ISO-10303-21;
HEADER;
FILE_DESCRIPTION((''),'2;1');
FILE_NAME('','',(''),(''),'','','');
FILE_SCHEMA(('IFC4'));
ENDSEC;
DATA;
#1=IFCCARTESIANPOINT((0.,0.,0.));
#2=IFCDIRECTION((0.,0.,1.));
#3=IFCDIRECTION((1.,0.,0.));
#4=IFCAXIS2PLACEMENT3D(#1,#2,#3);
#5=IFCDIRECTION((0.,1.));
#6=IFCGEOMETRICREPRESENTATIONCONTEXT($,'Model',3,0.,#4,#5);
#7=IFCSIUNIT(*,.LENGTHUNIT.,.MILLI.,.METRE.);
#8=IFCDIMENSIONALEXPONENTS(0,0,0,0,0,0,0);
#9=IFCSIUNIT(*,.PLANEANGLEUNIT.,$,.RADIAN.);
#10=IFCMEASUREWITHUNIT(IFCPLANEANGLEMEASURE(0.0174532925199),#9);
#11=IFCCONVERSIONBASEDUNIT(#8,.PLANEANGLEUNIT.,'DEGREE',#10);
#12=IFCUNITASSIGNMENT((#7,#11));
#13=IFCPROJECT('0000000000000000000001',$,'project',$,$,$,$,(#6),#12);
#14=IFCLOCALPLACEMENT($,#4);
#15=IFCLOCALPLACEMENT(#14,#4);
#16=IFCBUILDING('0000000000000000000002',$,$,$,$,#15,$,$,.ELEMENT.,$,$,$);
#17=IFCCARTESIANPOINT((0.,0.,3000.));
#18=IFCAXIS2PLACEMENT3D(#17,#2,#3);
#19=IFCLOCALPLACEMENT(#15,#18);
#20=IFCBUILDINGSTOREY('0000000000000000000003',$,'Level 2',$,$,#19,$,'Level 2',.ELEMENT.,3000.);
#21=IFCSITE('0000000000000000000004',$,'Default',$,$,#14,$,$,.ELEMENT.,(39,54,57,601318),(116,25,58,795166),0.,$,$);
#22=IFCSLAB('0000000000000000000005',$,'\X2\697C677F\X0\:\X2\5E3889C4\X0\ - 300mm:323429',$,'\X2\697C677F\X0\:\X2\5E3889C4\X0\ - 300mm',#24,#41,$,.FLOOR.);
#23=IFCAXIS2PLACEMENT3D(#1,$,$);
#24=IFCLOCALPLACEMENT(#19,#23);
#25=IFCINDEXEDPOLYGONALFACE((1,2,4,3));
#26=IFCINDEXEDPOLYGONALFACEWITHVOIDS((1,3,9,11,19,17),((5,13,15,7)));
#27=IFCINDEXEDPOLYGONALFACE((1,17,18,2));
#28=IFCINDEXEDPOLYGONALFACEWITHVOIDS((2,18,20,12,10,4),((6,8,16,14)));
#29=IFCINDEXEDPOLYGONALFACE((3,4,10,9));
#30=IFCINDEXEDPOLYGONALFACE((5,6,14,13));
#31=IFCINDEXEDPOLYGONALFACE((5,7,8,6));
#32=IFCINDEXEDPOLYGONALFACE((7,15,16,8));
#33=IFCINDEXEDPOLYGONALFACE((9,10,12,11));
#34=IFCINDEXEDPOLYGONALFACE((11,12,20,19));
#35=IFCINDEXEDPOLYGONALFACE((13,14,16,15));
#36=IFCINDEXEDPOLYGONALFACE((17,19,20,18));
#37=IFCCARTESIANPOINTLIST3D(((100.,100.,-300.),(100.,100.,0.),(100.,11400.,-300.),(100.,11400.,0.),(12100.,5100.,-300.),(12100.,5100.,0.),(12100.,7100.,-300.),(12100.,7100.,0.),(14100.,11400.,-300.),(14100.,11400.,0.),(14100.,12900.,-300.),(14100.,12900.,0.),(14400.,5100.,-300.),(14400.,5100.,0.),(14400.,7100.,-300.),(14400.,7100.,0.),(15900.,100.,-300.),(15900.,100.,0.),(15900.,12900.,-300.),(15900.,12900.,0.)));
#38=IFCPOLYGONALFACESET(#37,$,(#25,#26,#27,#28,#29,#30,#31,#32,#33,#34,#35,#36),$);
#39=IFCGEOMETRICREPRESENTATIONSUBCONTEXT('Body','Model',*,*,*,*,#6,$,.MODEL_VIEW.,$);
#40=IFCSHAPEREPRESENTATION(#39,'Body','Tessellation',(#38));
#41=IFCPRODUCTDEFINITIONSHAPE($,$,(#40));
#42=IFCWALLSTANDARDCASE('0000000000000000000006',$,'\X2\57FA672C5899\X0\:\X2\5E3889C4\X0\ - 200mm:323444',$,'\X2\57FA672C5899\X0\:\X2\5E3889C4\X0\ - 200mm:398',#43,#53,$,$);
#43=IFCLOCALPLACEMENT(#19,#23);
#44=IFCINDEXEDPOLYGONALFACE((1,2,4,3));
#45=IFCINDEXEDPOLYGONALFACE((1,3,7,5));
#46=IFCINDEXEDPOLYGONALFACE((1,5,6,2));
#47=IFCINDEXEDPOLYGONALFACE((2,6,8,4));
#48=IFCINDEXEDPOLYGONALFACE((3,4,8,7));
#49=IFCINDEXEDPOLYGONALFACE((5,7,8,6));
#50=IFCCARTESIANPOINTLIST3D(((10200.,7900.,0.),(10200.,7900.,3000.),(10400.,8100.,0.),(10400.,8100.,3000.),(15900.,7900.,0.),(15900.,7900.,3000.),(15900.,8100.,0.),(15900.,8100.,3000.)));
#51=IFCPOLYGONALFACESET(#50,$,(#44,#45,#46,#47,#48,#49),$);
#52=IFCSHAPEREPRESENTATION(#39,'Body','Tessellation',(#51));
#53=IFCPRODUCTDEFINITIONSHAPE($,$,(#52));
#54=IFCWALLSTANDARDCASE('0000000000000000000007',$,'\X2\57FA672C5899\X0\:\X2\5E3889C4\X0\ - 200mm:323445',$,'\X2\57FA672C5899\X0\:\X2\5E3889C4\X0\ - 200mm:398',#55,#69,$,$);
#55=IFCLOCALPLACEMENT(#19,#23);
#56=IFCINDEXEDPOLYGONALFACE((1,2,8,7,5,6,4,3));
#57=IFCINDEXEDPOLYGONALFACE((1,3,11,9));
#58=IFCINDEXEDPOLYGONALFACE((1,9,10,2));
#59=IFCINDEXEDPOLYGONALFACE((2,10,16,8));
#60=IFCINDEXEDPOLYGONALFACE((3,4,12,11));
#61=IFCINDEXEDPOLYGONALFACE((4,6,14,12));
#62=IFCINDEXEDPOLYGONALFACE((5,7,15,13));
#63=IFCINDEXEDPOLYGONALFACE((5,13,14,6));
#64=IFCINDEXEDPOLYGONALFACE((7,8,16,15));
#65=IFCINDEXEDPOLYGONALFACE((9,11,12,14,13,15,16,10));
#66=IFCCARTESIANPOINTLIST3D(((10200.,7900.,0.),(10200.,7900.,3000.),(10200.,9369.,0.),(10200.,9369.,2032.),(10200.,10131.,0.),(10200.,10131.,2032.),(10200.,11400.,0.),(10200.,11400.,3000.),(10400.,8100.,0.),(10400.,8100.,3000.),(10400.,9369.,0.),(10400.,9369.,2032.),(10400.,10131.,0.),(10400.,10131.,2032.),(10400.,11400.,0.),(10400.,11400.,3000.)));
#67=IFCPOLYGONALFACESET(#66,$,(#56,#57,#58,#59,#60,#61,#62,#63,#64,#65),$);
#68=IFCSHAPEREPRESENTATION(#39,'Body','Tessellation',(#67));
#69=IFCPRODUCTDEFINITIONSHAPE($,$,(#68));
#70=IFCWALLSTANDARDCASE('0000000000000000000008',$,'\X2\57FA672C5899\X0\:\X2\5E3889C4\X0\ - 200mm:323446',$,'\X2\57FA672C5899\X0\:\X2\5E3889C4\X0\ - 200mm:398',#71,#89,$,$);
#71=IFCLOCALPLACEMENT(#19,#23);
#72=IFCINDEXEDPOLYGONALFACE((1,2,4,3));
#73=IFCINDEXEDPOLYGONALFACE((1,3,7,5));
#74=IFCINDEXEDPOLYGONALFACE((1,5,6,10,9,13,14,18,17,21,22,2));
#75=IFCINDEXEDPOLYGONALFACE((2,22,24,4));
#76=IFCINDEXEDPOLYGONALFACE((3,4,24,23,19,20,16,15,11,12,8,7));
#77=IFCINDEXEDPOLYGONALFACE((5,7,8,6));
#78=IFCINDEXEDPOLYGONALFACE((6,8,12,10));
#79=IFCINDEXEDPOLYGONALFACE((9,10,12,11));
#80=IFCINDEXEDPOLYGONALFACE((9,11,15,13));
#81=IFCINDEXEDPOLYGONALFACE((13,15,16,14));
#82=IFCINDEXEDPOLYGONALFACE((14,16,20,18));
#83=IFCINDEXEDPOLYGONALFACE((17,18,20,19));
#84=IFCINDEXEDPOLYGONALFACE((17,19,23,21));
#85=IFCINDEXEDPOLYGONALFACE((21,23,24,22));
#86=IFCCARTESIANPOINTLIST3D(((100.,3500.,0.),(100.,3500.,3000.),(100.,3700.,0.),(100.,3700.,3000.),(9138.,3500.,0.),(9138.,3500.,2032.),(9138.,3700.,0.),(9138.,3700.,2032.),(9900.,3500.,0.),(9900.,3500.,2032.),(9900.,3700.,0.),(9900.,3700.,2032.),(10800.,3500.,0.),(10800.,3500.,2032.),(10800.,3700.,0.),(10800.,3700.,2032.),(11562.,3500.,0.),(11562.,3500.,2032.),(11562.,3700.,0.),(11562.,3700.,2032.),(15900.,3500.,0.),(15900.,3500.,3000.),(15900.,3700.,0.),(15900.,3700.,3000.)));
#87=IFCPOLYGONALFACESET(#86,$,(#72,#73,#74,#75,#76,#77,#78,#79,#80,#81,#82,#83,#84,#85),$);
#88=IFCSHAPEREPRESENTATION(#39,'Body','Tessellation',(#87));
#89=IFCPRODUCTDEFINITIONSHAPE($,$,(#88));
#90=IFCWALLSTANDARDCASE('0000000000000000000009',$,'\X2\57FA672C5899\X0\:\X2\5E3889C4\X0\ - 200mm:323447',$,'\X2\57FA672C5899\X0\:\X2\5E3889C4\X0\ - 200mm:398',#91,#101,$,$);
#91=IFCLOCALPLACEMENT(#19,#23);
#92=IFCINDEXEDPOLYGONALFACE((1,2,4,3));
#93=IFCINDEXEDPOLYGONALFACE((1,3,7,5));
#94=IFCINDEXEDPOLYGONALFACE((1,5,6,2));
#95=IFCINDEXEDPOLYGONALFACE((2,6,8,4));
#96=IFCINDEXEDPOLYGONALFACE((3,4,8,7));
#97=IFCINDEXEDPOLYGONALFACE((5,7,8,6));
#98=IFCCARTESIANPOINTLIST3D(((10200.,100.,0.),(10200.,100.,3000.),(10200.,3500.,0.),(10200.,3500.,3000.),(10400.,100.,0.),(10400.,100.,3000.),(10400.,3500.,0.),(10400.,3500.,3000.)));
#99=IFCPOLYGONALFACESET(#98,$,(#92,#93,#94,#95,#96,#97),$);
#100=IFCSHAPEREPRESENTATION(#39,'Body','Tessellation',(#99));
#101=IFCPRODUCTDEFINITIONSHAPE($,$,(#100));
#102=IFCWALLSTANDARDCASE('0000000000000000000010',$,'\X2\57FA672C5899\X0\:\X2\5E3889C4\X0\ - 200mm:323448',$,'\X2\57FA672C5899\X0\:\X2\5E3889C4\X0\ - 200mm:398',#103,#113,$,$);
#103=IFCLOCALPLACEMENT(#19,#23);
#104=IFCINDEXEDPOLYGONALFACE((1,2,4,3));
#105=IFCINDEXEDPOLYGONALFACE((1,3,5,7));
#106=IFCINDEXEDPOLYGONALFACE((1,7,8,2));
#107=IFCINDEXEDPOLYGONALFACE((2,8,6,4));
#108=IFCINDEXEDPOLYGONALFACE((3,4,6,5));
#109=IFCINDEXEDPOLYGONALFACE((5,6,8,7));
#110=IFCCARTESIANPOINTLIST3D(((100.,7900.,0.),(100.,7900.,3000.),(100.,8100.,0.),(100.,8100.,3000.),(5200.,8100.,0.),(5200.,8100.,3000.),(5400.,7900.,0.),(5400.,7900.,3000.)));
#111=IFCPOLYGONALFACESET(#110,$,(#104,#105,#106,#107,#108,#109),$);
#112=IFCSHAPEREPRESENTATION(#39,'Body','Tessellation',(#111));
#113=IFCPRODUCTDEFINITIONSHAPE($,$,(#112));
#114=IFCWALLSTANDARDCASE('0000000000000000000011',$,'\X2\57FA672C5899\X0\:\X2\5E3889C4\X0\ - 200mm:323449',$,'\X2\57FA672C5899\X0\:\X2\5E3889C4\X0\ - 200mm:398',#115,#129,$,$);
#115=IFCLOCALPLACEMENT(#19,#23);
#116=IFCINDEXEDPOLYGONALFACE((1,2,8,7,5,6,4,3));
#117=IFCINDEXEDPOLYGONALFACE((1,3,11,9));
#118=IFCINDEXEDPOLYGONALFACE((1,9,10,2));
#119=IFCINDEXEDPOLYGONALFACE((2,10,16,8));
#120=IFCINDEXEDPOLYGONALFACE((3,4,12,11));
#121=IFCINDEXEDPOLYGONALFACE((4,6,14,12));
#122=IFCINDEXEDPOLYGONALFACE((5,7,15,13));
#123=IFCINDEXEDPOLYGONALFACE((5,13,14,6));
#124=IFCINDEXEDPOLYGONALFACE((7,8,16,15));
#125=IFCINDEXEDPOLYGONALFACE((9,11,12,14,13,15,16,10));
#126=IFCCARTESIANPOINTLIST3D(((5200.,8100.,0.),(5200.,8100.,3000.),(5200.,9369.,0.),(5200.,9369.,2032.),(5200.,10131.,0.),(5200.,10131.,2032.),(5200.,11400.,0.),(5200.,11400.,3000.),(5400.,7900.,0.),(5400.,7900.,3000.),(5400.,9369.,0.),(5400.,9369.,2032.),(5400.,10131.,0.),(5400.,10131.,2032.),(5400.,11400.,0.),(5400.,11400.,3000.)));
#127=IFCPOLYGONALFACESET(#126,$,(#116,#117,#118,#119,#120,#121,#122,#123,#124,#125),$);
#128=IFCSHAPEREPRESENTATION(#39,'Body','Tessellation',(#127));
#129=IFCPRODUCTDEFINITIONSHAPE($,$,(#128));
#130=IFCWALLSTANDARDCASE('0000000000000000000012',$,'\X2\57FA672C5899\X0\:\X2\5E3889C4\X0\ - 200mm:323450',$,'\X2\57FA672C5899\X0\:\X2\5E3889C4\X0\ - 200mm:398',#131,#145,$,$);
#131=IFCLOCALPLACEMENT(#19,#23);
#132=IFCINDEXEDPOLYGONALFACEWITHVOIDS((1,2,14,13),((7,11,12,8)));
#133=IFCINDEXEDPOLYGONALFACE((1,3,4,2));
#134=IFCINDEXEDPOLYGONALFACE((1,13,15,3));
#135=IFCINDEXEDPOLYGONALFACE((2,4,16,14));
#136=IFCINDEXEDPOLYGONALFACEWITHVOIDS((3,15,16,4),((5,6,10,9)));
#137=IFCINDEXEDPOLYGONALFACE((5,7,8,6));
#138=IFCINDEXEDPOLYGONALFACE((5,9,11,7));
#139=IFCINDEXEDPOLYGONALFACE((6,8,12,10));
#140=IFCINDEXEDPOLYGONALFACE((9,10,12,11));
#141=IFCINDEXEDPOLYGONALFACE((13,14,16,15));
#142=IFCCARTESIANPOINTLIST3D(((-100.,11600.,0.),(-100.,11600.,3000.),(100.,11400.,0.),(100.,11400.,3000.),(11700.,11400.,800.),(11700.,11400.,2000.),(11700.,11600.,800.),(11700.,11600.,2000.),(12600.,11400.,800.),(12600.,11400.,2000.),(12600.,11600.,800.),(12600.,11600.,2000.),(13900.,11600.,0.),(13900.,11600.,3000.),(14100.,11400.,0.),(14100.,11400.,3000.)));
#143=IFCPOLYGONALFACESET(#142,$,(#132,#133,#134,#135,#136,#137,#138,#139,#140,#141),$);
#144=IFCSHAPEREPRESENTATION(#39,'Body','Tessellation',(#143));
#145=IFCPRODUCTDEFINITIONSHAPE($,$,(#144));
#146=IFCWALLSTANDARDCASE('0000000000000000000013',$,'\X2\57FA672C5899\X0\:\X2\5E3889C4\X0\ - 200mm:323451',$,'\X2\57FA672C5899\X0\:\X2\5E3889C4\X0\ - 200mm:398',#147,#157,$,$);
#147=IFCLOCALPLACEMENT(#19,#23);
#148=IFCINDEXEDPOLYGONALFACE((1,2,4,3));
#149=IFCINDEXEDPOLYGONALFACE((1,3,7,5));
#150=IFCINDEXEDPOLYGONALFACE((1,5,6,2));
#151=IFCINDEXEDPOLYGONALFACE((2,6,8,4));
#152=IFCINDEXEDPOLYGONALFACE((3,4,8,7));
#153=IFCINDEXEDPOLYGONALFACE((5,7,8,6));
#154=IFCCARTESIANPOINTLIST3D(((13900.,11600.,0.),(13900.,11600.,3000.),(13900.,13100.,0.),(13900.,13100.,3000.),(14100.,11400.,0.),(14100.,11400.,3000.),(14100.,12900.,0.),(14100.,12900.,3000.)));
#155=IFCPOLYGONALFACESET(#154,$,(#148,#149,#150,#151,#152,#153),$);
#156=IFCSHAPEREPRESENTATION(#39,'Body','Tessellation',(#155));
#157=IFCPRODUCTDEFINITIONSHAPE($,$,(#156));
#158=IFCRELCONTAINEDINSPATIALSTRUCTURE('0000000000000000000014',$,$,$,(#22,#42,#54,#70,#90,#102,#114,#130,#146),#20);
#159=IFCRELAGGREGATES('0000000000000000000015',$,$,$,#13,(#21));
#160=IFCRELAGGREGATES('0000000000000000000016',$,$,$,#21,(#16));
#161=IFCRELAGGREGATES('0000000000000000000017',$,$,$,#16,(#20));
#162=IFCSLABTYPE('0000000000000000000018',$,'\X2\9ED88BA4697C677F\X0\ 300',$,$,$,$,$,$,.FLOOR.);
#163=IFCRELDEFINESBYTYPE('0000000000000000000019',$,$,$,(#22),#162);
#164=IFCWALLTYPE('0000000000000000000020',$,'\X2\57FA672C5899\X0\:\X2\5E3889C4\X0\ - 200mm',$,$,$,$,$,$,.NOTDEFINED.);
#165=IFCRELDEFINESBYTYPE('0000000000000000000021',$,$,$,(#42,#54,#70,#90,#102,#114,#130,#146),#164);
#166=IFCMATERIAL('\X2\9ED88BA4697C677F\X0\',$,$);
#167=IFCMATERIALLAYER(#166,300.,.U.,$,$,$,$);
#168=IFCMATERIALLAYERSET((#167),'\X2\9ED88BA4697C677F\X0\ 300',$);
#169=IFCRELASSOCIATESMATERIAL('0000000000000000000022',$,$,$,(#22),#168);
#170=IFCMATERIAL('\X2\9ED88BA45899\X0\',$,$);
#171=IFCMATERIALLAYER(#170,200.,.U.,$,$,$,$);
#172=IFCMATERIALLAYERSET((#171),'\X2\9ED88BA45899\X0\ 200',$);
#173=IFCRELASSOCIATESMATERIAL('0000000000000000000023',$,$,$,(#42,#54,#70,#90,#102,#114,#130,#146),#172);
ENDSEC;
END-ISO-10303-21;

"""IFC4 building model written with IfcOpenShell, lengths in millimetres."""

from ifc_helpers import new_model, entity, si_unit, converted_unit, direction, frame, origin_with_axes, place, context, subcontext, project, spatial, polyline, outline, extrude, material, layer, layer_set, layer_usage, type_object, element, save


model = new_model("IFC4")

# Units and contexts
model_context = context("Model", 3, precision=0.0, world=origin_with_axes(), true_north=direction((0.0, 1.0)))
body_context = subcontext(model_context, "Body", "Model", "MODEL_VIEW")
ifc_project = project(units=[si_unit("LENGTHUNIT", "METRE", prefix="MILLI"), converted_unit("PLANEANGLEUNIT", "DEGREE", entity("IfcPlaneAngleMeasure", 0.0174532925199), si_unit("PLANEANGLEUNIT", "RADIAN"), dimensions=[0, 0, 0, 0, 0, 0, 0])], contexts=[model_context])

# Site, building, storey
site_placement = place(None, origin_with_axes())
site = spatial("IfcSite", under=ifc_project, at=site_placement, Name="Default", CompositionType="ELEMENT", RefLatitude=(39, 54, 57, 601318), RefLongitude=(116, 25, 58, 795166), RefElevation=0.0)
building_placement = place(site_placement, origin_with_axes())
building = spatial("IfcBuilding", under=site, at=building_placement, CompositionType="ELEMENT")
storey_placement = place(building_placement, frame((0.0, 0.0, 3000.0), z_axis=(0.0, 0.0, 1.0), x_axis=(1.0, 0.0, 0.0)))
storey = spatial("IfcBuildingStorey", under=building, at=storey_placement, Name="Level 2", LongName="Level 2", CompositionType="ELEMENT", Elevation=3000.0)

# Slab, opening
ifc_material_1 = material(Name="默认楼板")
ifc_layer_1 = layer(ifc_material_1, 300.0, ventilated="UNKNOWN")
ifc_layer_set_1 = layer_set([ifc_layer_1], Name="默认楼板 300")
ifc_layer_usage_1 = layer_usage(ifc_layer_set_1, "AXIS3", "NEGATIVE", 300.0)
slab_type = type_object("IfcSlabType", Name="默认楼板 300", PredefinedType="FLOOR")
slab_placement = place(storey_placement, frame((15900.0, 12900.0, -300.0), z_axis=(0.0, 0.0, 1.0), x_axis=(1.0, 0.0, 0.0)))
slab = element("IfcSlab", 1, at=slab_placement, inside=storey, type_object=slab_type, material=ifc_layer_usage_1, Name="楼板:常规 - 300mm:323429", ObjectType="楼板:常规 - 300mm", PredefinedType="FLOOR", context=body_context, shape_type="SweptSolid", body=[
    extrude(outline(polyline([(0.0, 0.0), (-1800.0, 0.0), (-1800.0, -1500.0), (-15800.0, -1500.0), (-15800.0, -12800.0), (0.0, -12800.0), (0.0, 0.0)])), origin_with_axes(), (0.0, 0.0, 1.0), 300.0),
])
opening_1_placement = place(slab_placement, origin_with_axes())
element("IfcOpeningElement", 2, at=opening_1_placement, cuts=slab, context=body_context, shape_type="SweptSolid", body=[
    extrude(outline(polyline([(-3800.0, -7800.0), (-1500.0, -7800.0), (-1500.0, -5800.0), (-3800.0, -5800.0), (-3800.0, -7800.0)])), origin_with_axes(), (0.0, 0.0, 1.0), 300.0),
])

# Wall
ifc_material_2 = material(Name="默认墙")
ifc_layer_2 = layer(ifc_material_2, 200.0, ventilated="UNKNOWN")
ifc_layer_set_2 = layer_set([ifc_layer_2], Name="默认墙 200")
ifc_layer_usage_2 = layer_usage(ifc_layer_set_2, "AXIS2", "POSITIVE", -100.0)
wall_type = type_object("IfcWallType", Name="基本墙:常规 - 200mm", PredefinedType="NOTDEFINED")
wall_1_placement = place(storey_placement, frame((10300.0, 8000.0, 0.0), z_axis=(0.0, 0.0, 1.0), x_axis=(1.0, 0.0, 0.0)))
element("IfcWallStandardCase", 3, at=wall_1_placement, inside=storey, type_object=wall_type, material=ifc_layer_usage_2, Name="基本墙:常规 - 200mm:323444", ObjectType="基本墙:常规 - 200mm:398", context=body_context, shape_type="SweptSolid", body=[
    extrude(outline(polyline([(-100.0, -100.0), (5600.0, -100.0), (5600.0, 100.0), (100.0, 100.0), (-100.0, -100.0)])), origin_with_axes(), (0.0, 0.0, 1.0), 3000.0),
])

# Wall, opening
ifc_layer_usage_3 = layer_usage(ifc_layer_set_2, "AXIS2", "POSITIVE", -100.0)
wall_2_placement = place(storey_placement, frame((10300.0, 11500.0, 0.0), z_axis=(0.0, 0.0, 1.0), x_axis=(0.0, -1.0, 0.0)))
wall_2 = element("IfcWallStandardCase", 4, at=wall_2_placement, inside=storey, type_object=wall_type, material=ifc_layer_usage_3, Name="基本墙:常规 - 200mm:323445", ObjectType="基本墙:常规 - 200mm:398", context=body_context, shape_type="SweptSolid", body=[
    extrude(outline(polyline([(100.0, -100.0), (3600.0, -100.0), (3400.0, 100.0), (100.0, 100.0), (100.0, -100.0)])), origin_with_axes(), (0.0, 0.0, 1.0), 3000.0),
])
opening_2_placement = place(wall_2_placement, frame((1750.0, 0.0, 0.0), z_axis=(0.0, 0.0, 1.0), x_axis=(1.0, 0.0, 0.0)))
element("IfcOpeningElement", 5, at=opening_2_placement, cuts=wall_2, context=body_context, shape_type="SweptSolid", body=[
    extrude(outline(polyline([(-381.0, -2032.0), (381.0, -2032.0), (381.0, 0.0), (-381.0, 0.0), (-381.0, -2032.0)])), frame((0.0, 100.0, 0.0), z_axis=(0.0, -1.0, 0.0), x_axis=(-1.0, 0.0, 0.0)), (0.0, 0.0, 1.0), 200.0),
])

# Wall, openings
ifc_layer_usage_4 = layer_usage(ifc_layer_set_2, "AXIS2", "POSITIVE", -100.0)
wall_3_placement = place(storey_placement, frame((16000.0, 3600.0, 0.0), z_axis=(0.0, 0.0, 1.0), x_axis=(-1.0, 0.0, 0.0)))
wall_3 = element("IfcWallStandardCase", 6, at=wall_3_placement, inside=storey, type_object=wall_type, material=ifc_layer_usage_4, Name="基本墙:常规 - 200mm:323446", ObjectType="基本墙:常规 - 200mm:398", context=body_context, shape_type="SweptSolid", body=[
    extrude(outline(polyline([(100.0, -100.0), (15900.0, -100.0), (15900.0, 100.0), (100.0, 100.0), (100.0, -100.0)])), origin_with_axes(), (0.0, 0.0, 1.0), 3000.0),
])
opening_3_placement = place(wall_3_placement, frame((6481.0, 0.0, 0.0), z_axis=(0.0, 0.0, 1.0), x_axis=(1.0, 0.0, 0.0)))
element("IfcOpeningElement", 7, at=opening_3_placement, cuts=wall_3, context=body_context, shape_type="SweptSolid", body=[
    extrude(outline(polyline([(-381.0, 0.0), (-381.0, -2032.0), (381.0, -2032.0), (381.0, 0.0), (-381.0, 0.0)])), frame((0.0, 100.0, 0.0), z_axis=(0.0, 1.0, 0.0), x_axis=(1.0, 0.0, 0.0)), (0.0, 0.0, -1.0), 200.0),
])
opening_4_placement = place(wall_3_placement, frame((4819.0, 0.0, 0.0), z_axis=(0.0, 0.0, 1.0), x_axis=(1.0, 0.0, 0.0)))
element("IfcOpeningElement", 8, at=opening_4_placement, cuts=wall_3, context=body_context, shape_type="SweptSolid", body=[
    extrude(outline(polyline([(-381.0, -2032.0), (381.0, -2032.0), (381.0, 0.0), (-381.0, 0.0), (-381.0, -2032.0)])), frame((0.0, 100.0, 0.0), z_axis=(0.0, -1.0, 0.0), x_axis=(-1.0, 0.0, 0.0)), (0.0, 0.0, 1.0), 200.0),
])

# Walls
ifc_layer_usage_5 = layer_usage(ifc_layer_set_2, "AXIS2", "POSITIVE", -100.0)
wall_4_placement = place(storey_placement, frame((10300.0, 3600.0, 0.0), z_axis=(0.0, 0.0, 1.0), x_axis=(0.0, -1.0, 0.0)))
element("IfcWallStandardCase", 9, at=wall_4_placement, inside=storey, type_object=wall_type, material=ifc_layer_usage_5, Name="基本墙:常规 - 200mm:323447", ObjectType="基本墙:常规 - 200mm:398", context=body_context, shape_type="SweptSolid", body=[
    extrude(outline(polyline([(100.0, -100.0), (3500.0, -100.0), (3500.0, 100.0), (100.0, 100.0), (100.0, -100.0)])), origin_with_axes(), (0.0, 0.0, 1.0), 3000.0),
])
ifc_layer_usage_6 = layer_usage(ifc_layer_set_2, "AXIS2", "POSITIVE", -100.0)
wall_5_placement = place(storey_placement, frame((0.0, 8000.0, 0.0), z_axis=(0.0, 0.0, 1.0), x_axis=(1.0, 0.0, 0.0)))
element("IfcWallStandardCase", 10, at=wall_5_placement, inside=storey, type_object=wall_type, material=ifc_layer_usage_6, Name="基本墙:常规 - 200mm:323448", ObjectType="基本墙:常规 - 200mm:398", context=body_context, shape_type="SweptSolid", body=[
    extrude(outline(polyline([(100.0, -100.0), (5400.0, -100.0), (5200.0, 100.0), (100.0, 100.0), (100.0, -100.0)])), origin_with_axes(), (0.0, 0.0, 1.0), 3000.0),
])

# Walls, openings
ifc_layer_usage_7 = layer_usage(ifc_layer_set_2, "AXIS2", "POSITIVE", -100.0)
wall_6_placement = place(storey_placement, frame((5300.0, 8000.0, 0.0), z_axis=(0.0, 0.0, 1.0), x_axis=(0.0, 1.0, 0.0)))
wall_6 = element("IfcWallStandardCase", 11, at=wall_6_placement, inside=storey, type_object=wall_type, material=ifc_layer_usage_7, Name="基本墙:常规 - 200mm:323449", ObjectType="基本墙:常规 - 200mm:398", context=body_context, shape_type="SweptSolid", body=[
    extrude(outline(polyline([(-100.0, -100.0), (3400.0, -100.0), (3400.0, 100.0), (100.0, 100.0), (-100.0, -100.0)])), origin_with_axes(), (0.0, 0.0, 1.0), 3000.0),
])
opening_5_placement = place(wall_6_placement, frame((1750.0, 0.0, 0.0), z_axis=(0.0, 0.0, 1.0), x_axis=(1.0, 0.0, 0.0)))
element("IfcOpeningElement", 12, at=opening_5_placement, cuts=wall_6, context=body_context, shape_type="SweptSolid", body=[
    extrude(outline(polyline([(-381.0, -2032.0), (381.0, -2032.0), (381.0, 0.0), (-381.0, 0.0), (-381.0, -2032.0)])), frame((0.0, 100.0, 0.0), z_axis=(0.0, -1.0, 0.0), x_axis=(-1.0, 0.0, 0.0)), (0.0, 0.0, 1.0), 200.0),
])
ifc_layer_usage_8 = layer_usage(ifc_layer_set_2, "AXIS2", "POSITIVE", -100.0)
wall_7_placement = place(storey_placement, frame((0.0, 11500.0, 0.0), z_axis=(0.0, 0.0, 1.0), x_axis=(1.0, 0.0, 0.0)))
wall_7 = element("IfcWallStandardCase", 13, at=wall_7_placement, inside=storey, type_object=wall_type, material=ifc_layer_usage_8, Name="基本墙:常规 - 200mm:323450", ObjectType="基本墙:常规 - 200mm:398", context=body_context, shape_type="SweptSolid", body=[
    extrude(outline(polyline([(100.0, -100.0), (14100.0, -100.0), (13900.0, 100.0), (-100.0, 100.0), (100.0, -100.0)])), origin_with_axes(), (0.0, 0.0, 1.0), 3000.0),
])
opening_6_placement = place(wall_7_placement, frame((12150.0, 0.0, 800.0), z_axis=(0.0, 0.0, 1.0), x_axis=(1.0, 0.0, 0.0)))
element("IfcOpeningElement", 14, at=opening_6_placement, cuts=wall_7, context=body_context, shape_type="SweptSolid", body=[
    extrude(outline(polyline([(450.0, -1200.0), (450.0, 0.0), (-450.0, 0.0), (-450.0, -1200.0), (450.0, -1200.0)])), frame((0.0, 100.0, 0.0), z_axis=(0.0, -1.0, 0.0), x_axis=(-1.0, 0.0, 0.0)), (0.0, 0.0, 1.0), 200.0),
])

# Wall
ifc_layer_usage_9 = layer_usage(ifc_layer_set_2, "AXIS2", "POSITIVE", -100.0)
wall_8_placement = place(storey_placement, frame((14000.0, 11500.0, 0.0), z_axis=(0.0, 0.0, 1.0), x_axis=(0.0, 1.0, 0.0)))
element("IfcWallStandardCase", 15, at=wall_8_placement, inside=storey, type_object=wall_type, material=ifc_layer_usage_9, Name="基本墙:常规 - 200mm:323451", ObjectType="基本墙:常规 - 200mm:398", context=body_context, shape_type="SweptSolid", body=[
    extrude(outline(polyline([(-100.0, -100.0), (1400.0, -100.0), (1600.0, 100.0), (100.0, 100.0), (-100.0, -100.0)])), origin_with_axes(), (0.0, 0.0, 1.0), 3000.0),
])

save(model, "model.ifc")
